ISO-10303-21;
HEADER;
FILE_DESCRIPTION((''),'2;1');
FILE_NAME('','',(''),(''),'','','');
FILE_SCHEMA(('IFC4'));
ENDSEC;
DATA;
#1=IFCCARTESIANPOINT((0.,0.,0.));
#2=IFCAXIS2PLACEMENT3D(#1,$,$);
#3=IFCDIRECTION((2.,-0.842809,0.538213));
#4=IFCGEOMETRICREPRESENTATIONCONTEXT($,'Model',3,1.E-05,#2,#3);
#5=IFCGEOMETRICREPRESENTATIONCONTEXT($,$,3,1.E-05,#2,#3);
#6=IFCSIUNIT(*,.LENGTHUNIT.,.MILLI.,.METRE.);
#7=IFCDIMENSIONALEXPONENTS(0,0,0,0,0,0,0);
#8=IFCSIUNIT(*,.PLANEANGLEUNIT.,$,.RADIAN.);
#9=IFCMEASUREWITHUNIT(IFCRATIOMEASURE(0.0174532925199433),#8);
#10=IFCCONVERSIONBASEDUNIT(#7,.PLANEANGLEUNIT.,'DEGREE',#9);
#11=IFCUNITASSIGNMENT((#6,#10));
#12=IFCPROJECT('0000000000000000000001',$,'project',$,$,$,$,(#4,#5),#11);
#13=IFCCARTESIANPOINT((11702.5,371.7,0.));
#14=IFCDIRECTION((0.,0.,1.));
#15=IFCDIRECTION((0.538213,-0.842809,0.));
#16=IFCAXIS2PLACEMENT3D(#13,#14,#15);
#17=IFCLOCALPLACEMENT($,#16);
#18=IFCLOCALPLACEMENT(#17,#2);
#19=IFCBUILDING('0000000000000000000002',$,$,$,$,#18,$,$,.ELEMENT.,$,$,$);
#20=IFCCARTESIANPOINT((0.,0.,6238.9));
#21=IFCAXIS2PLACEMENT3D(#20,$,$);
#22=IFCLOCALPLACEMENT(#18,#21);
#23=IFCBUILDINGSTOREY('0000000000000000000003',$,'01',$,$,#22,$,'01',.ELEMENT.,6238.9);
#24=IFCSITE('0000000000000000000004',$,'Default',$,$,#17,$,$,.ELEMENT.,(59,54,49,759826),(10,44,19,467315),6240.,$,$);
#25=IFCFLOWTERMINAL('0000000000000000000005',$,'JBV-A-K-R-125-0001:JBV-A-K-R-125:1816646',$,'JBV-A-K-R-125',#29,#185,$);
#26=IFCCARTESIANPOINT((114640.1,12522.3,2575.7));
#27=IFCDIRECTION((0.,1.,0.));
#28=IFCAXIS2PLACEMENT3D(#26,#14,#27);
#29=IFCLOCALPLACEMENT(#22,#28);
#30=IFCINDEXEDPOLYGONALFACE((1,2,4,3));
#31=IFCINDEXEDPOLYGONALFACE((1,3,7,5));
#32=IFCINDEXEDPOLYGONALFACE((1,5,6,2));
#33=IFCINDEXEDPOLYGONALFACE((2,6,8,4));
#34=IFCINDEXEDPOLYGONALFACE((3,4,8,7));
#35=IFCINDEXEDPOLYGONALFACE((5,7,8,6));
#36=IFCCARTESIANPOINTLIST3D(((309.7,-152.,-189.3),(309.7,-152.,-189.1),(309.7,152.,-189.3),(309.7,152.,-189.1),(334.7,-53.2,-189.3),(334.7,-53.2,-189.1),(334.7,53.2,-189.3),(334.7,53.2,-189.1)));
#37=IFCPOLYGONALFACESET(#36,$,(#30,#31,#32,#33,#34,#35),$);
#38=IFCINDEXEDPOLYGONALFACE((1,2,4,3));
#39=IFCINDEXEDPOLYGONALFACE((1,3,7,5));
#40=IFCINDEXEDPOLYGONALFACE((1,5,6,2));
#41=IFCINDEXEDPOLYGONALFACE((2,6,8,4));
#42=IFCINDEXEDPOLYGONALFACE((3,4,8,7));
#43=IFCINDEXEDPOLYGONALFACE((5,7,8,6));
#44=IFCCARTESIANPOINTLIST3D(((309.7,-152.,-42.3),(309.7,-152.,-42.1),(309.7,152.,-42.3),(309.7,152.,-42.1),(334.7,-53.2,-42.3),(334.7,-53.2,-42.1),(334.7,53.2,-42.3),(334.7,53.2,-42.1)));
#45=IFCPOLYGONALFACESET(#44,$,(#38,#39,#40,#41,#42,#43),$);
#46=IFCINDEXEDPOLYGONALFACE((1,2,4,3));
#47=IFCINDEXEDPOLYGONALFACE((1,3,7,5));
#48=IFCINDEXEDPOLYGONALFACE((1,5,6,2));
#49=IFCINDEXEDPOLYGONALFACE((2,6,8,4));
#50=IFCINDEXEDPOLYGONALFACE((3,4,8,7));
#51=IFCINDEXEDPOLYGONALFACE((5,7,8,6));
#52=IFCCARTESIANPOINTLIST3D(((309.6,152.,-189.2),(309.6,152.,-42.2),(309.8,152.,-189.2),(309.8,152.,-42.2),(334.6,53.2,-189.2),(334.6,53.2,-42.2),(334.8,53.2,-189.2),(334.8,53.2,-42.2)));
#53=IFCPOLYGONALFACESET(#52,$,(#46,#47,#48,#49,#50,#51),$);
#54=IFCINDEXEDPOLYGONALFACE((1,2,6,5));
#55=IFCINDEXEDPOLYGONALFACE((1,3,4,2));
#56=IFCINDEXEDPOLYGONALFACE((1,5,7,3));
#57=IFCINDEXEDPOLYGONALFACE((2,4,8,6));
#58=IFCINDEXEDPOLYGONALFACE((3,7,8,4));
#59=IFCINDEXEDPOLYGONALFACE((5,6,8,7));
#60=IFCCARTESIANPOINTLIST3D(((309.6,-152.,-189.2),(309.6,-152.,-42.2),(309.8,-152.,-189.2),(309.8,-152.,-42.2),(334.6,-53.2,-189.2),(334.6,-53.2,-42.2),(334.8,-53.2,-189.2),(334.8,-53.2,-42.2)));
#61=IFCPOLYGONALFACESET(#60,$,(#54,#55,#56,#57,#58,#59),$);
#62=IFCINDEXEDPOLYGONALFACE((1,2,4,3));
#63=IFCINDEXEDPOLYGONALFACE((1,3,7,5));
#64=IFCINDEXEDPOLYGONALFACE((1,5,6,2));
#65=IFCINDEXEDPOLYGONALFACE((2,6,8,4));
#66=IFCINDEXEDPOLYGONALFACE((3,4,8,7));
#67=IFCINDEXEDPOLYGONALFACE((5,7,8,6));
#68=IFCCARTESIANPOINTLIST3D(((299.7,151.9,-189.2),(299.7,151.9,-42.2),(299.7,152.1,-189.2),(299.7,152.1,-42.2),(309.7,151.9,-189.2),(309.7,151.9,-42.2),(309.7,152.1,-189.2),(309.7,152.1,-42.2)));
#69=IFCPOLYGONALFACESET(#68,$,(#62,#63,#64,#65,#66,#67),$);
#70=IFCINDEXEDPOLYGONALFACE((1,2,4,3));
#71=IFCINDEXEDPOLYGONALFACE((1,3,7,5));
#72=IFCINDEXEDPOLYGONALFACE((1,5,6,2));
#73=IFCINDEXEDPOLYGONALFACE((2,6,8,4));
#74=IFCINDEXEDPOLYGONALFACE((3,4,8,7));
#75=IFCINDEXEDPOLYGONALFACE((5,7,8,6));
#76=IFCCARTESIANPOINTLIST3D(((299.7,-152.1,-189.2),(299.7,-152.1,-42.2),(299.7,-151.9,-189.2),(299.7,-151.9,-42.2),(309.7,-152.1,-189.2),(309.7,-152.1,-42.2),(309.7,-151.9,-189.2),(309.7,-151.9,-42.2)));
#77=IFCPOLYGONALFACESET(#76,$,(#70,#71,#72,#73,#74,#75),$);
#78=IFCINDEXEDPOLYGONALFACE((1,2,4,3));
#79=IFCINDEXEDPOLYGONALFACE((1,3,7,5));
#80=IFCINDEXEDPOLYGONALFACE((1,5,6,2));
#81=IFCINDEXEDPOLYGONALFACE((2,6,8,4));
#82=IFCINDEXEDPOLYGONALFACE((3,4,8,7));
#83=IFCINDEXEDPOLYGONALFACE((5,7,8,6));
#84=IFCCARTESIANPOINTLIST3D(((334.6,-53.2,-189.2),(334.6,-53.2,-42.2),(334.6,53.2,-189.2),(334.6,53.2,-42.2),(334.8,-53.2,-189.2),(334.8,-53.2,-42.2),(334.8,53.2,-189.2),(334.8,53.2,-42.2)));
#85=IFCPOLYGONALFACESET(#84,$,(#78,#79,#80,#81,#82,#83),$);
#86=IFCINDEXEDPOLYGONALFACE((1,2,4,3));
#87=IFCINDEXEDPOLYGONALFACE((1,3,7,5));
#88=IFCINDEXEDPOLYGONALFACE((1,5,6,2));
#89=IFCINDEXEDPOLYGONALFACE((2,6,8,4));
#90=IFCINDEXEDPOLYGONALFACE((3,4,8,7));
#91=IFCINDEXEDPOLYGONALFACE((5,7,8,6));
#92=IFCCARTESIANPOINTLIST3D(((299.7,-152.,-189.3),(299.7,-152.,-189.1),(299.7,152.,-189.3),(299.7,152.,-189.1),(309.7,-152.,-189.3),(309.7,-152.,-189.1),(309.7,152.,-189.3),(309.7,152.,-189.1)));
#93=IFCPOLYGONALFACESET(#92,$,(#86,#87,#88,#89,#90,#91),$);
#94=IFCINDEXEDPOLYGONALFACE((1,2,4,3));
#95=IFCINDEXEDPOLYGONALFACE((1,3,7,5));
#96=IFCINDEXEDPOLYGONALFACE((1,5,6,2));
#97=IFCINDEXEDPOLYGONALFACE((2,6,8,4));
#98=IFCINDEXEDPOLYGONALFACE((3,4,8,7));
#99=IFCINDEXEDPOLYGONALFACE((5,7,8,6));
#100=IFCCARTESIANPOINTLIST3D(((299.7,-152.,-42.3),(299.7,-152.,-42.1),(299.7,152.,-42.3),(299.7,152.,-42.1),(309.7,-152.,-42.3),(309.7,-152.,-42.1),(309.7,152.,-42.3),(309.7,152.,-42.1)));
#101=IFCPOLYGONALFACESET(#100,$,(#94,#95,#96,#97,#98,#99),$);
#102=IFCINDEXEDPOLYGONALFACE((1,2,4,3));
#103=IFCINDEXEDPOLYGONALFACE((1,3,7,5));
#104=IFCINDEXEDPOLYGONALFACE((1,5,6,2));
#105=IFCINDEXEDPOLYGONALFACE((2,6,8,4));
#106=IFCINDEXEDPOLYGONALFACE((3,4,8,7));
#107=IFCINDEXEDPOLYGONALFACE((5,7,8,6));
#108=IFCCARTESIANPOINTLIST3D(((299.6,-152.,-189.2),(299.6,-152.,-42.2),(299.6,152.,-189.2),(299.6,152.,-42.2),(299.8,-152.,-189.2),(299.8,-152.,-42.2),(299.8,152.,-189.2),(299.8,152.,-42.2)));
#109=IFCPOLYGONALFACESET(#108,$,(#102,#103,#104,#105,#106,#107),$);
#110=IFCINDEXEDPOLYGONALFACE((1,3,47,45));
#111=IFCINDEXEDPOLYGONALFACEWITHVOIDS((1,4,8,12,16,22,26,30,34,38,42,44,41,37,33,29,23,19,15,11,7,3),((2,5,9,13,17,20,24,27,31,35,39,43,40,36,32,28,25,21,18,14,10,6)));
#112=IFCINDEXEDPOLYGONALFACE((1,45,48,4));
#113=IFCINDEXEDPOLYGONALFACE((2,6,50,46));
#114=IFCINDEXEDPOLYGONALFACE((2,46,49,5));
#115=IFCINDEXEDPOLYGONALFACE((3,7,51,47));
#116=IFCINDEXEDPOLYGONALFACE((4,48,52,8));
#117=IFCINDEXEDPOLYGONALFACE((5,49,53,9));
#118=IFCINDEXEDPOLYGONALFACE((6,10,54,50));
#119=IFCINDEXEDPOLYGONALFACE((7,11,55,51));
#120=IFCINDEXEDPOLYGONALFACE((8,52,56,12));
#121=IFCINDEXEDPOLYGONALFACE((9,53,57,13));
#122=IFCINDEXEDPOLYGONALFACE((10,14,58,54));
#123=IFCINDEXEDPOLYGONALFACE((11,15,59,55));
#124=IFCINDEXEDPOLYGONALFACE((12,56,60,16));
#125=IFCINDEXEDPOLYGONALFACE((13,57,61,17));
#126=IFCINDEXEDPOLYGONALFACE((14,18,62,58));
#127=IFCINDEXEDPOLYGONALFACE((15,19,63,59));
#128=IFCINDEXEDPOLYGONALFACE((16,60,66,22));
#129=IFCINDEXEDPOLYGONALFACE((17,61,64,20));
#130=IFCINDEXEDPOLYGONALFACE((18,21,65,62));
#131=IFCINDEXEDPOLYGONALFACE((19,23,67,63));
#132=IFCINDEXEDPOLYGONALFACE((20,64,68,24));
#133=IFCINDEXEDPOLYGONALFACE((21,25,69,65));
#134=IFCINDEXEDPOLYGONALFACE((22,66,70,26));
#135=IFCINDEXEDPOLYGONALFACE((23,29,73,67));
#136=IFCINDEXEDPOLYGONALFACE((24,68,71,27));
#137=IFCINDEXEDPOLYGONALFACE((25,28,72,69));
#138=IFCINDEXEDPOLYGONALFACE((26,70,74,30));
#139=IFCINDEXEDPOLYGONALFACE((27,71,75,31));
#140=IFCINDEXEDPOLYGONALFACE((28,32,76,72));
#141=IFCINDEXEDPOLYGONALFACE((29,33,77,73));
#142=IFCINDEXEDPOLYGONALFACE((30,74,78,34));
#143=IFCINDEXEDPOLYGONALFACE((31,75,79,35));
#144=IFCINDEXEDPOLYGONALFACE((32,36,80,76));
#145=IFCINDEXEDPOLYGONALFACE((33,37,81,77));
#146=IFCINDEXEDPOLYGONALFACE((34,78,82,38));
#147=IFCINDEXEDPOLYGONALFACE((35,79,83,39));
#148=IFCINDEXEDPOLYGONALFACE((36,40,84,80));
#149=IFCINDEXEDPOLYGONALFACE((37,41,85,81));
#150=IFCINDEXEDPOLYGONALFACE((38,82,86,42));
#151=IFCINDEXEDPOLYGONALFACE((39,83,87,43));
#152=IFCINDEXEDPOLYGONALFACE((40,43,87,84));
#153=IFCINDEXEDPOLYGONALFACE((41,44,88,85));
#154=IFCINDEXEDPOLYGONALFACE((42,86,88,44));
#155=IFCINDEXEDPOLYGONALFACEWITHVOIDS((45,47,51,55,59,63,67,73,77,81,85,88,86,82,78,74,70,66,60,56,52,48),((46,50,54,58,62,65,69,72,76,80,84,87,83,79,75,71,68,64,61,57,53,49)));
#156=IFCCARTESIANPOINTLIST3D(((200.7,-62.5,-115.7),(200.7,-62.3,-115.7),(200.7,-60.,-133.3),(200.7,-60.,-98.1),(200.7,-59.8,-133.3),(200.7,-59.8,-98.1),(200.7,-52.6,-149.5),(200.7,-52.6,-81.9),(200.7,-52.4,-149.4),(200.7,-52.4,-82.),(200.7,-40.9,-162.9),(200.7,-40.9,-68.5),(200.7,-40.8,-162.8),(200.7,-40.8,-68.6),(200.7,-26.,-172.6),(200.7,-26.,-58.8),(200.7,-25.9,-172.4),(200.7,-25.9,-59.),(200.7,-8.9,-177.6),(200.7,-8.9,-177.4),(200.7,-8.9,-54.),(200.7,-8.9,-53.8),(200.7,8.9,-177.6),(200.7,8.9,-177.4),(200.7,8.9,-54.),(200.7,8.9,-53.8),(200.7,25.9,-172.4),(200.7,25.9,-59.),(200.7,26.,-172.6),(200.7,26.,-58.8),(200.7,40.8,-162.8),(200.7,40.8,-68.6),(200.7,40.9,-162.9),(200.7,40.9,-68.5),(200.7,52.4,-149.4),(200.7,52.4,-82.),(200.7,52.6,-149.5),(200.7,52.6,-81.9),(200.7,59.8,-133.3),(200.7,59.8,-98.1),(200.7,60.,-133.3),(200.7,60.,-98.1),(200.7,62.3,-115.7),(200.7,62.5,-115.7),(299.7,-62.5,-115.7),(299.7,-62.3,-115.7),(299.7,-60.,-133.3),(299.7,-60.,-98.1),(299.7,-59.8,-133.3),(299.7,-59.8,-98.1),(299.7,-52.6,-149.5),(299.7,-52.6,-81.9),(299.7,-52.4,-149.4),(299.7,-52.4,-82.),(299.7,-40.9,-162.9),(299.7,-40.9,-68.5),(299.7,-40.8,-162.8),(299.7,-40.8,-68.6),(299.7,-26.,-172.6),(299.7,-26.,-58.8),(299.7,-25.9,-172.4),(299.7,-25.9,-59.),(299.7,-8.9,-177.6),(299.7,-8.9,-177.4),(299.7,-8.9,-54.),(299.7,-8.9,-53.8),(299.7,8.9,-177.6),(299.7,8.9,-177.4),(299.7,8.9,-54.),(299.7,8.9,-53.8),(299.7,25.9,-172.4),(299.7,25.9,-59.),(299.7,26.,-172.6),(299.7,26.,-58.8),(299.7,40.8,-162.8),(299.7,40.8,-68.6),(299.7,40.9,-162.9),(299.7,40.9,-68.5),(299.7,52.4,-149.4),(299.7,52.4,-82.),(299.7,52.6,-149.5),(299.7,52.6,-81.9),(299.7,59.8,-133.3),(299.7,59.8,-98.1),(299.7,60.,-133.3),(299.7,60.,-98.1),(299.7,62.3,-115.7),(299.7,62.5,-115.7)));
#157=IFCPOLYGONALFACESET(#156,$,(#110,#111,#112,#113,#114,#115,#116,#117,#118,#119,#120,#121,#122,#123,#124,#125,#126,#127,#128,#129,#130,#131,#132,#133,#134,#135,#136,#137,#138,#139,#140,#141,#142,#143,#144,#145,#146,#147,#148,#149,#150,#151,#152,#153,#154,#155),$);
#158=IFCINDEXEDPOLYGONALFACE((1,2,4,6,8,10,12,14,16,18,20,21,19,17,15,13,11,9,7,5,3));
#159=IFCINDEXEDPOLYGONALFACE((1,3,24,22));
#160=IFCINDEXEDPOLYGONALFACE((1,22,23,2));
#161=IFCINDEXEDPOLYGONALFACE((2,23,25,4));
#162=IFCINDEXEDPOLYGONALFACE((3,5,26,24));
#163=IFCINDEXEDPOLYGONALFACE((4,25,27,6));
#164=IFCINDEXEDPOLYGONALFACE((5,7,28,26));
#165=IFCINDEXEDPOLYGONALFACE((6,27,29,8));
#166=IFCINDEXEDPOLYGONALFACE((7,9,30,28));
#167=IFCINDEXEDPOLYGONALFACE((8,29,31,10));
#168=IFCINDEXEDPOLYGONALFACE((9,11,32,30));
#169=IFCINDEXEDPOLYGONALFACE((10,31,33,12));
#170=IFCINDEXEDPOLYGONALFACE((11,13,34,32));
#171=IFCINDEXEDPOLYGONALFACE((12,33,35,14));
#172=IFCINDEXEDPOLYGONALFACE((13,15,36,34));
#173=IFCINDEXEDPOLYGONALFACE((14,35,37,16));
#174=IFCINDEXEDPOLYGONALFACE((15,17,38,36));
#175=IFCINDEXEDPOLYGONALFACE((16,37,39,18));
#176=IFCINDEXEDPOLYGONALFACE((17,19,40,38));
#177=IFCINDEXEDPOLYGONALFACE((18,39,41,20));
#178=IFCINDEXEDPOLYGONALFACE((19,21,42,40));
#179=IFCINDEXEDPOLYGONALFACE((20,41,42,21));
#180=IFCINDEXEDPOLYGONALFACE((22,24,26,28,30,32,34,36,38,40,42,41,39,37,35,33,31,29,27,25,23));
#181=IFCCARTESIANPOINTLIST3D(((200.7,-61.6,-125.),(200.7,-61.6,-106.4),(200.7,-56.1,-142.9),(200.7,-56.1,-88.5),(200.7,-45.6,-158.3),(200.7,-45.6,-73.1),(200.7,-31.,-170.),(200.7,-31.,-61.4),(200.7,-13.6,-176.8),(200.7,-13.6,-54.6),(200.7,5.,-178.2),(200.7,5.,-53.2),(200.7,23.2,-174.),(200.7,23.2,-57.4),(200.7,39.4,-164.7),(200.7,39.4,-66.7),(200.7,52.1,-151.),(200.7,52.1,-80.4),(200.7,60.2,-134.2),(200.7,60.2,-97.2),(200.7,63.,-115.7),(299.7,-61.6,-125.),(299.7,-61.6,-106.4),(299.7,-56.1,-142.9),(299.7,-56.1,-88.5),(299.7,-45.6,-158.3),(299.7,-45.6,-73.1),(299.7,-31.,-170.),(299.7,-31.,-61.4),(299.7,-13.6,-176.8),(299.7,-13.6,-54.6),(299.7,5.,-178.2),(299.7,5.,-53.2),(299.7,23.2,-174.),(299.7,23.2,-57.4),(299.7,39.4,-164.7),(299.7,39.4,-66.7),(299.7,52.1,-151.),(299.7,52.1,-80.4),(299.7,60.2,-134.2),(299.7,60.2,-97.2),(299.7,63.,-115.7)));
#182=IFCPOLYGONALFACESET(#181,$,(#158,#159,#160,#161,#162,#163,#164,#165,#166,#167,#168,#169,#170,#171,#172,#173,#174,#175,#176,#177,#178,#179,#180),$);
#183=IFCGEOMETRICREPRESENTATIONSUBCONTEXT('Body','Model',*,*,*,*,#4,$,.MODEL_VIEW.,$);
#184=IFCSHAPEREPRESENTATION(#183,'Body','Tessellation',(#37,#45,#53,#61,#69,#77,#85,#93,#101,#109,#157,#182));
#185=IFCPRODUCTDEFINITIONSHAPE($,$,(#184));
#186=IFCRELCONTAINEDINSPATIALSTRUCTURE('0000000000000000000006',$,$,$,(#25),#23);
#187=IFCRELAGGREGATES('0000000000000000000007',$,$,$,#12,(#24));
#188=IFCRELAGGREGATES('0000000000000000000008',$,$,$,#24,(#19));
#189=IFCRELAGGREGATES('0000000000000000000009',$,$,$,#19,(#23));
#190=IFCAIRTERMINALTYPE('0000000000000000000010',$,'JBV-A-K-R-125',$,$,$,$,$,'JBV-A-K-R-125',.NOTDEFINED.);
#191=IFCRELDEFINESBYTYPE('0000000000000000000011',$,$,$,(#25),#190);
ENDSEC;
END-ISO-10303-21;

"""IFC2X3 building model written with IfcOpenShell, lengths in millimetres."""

from ifc_helpers import new_model, entity, si_unit, converted_unit, direction, frame, frame_2d, origin, origin_2d_with_axis, place, context, subcontext, project, spatial, polyline, circle_curve, parameter, trimmed, segment, composite_curve, rectangle, circle, outline, extrude, source, transform, mapped, type_object, type_shapes, element, save


model = new_model("IFC2X3")

# Units and contexts
model_context = context("Model", 3, precision=1e-05, world=origin(), true_north=direction((2.0, -0.842809, 0.538213)))
context_of_model = context(None, 3, precision=1e-05, world=origin(), true_north=direction((2.0, -0.842809, 0.538213)))
body_context = subcontext(model_context, "Body", "Model", "MODEL_VIEW")
ifc_project = project(units=[si_unit("LENGTHUNIT", "METRE", prefix="MILLI"), converted_unit("PLANEANGLEUNIT", "DEGREE", entity("IfcRatioMeasure", 0.0174532925199433), si_unit("PLANEANGLEUNIT", "RADIAN"), dimensions=[0, 0, 0, 0, 0, 0, 0])], contexts=[model_context, context_of_model])

# Site, building, storey
site_placement = place(None, frame((11702.5, 371.7, 0.0), z_axis=(0.0, 0.0, 1.0), x_axis=(0.538213, -0.842809, 0.0)))
site = spatial("IfcSite", under=ifc_project, at=site_placement, Name="Default", CompositionType="ELEMENT", RefLatitude=(59, 54, 49, 759826), RefLongitude=(10, 44, 19, 467315), RefElevation=6240.0)
building_placement = place(site_placement, origin())
building = spatial("IfcBuilding", under=site, at=building_placement, CompositionType="ELEMENT")
storey_placement = place(building_placement, frame((0.0, 0.0, 6238.9)))
storey = spatial("IfcBuildingStorey", under=building, at=storey_placement, Name="01", LongName="01", CompositionType="ELEMENT", Elevation=6238.9)

# Flow terminal
air_terminal_type_1 = type_object("IfcAirTerminalType", Name="JBV-A-K-R-125", ElementType="JBV-A-K-R-125", PredefinedType="NOTDEFINED")
shared_shape_1 = source(origin(), body_context, "Body", "SweptSolid", [
    extrude(outline(polyline([(-152.0, -12.5), (152.0, -12.5), (53.2, 12.5), (-53.2, 12.5), (-152.0, -12.5)])), frame((322.2, 0.0, -189.3), z_axis=(0.0, 0.0, 1.0), x_axis=(0.0, -1.0, 0.0)), (0.0, 0.0, 1.0), 0.2),
    extrude(outline(polyline([(-152.0, -12.5), (152.0, -12.5), (53.2, 12.5), (-53.2, 12.5), (-152.0, -12.5)])), frame((322.2, 0.0, -42.3), z_axis=(0.0, 0.0, 1.0), x_axis=(0.0, -1.0, 0.0)), (0.0, 0.0, 1.0), 0.2),
    extrude(rectangle(XDim=0.2, YDim=101.9, at=frame_2d((0.0, 0.0), x_axis=(1.0, 0.0))), frame((322.2, 102.6, -189.2), z_axis=(0.0, 0.0, 1.0), x_axis=(0.969446, 0.245305, 0.0)), (0.0, 0.0, 1.0), 147.0),
    extrude(rectangle(XDim=0.2, YDim=101.9, at=frame_2d((0.0, 0.0), x_axis=(1.0, 0.0))), frame((322.2, -102.6, -189.2), z_axis=(0.0, 0.0, 1.0), x_axis=(-0.969446, 0.245305, 0.0)), (0.0, 0.0, 1.0), 147.0),
    extrude(rectangle(XDim=0.2, YDim=10.0, at=frame_2d((0.0, 0.0), x_axis=(1.0, 0.0))), frame((304.7, 152.0, -189.2), z_axis=(0.0, 0.0, 1.0), x_axis=(0.0, 1.0, 0.0)), (0.0, 0.0, 1.0), 147.0),
    extrude(rectangle(XDim=0.2, YDim=10.0, at=frame_2d((0.0, 0.0), x_axis=(1.0, 0.0))), frame((304.7, -152.0, -189.2), z_axis=(0.0, 0.0, 1.0), x_axis=(0.0, 1.0, 0.0)), (0.0, 0.0, 1.0), 147.0),
    extrude(rectangle(XDim=0.2, YDim=106.4, at=frame_2d((0.0, 0.0), x_axis=(1.0, 0.0))), frame((334.7, 0.0, -189.2)), (0.0, 0.0, 1.0), 147.0),
    extrude(rectangle(XDim=304.0, YDim=10.0, at=frame_2d((0.0, 0.0), x_axis=(1.0, 0.0))), frame((304.7, 0.0, -189.3), z_axis=(0.0, 0.0, 1.0), x_axis=(0.0, -1.0, 0.0)), (0.0, 0.0, 1.0), 0.2),
    extrude(rectangle(XDim=304.0, YDim=10.0, at=frame_2d((0.0, 0.0), x_axis=(1.0, 0.0))), frame((304.7, 0.0, -42.3), z_axis=(0.0, 0.0, 1.0), x_axis=(0.0, -1.0, 0.0)), (0.0, 0.0, 1.0), 0.2),
    extrude(rectangle(XDim=0.2, YDim=304.0, at=frame_2d((0.0, 0.0), x_axis=(1.0, 0.0))), frame((299.7, 0.0, -189.2)), (0.0, 0.0, 1.0), 147.0),
    extrude(outline(composite_curve([segment(trimmed(circle_curve(origin_2d_with_axis(), 62.5), [parameter(0.0)], [parameter(180.0)], True, "PARAMETER"), True, "CONTINUOUS"), segment(trimmed(circle_curve(origin_2d_with_axis(), 62.5), [parameter(180.0)], [parameter(360.0)], True, "PARAMETER"), True, "CONTINUOUS")], self_intersect=False), holes=[composite_curve([segment(trimmed(circle_curve(origin_2d_with_axis(), 62.3), [parameter(180.0)], [parameter(360.0)], True, "PARAMETER"), False, "CONTINUOUS"), segment(trimmed(circle_curve(origin_2d_with_axis(), 62.3), [parameter(0.0)], [parameter(180.0)], True, "PARAMETER"), False, "CONTINUOUS")], self_intersect=False)]), frame((200.7, 0.0, -115.7), z_axis=(1.0, 0.0, 0.0), x_axis=(0.0, 1.0, 0.0)), (0.0, 0.0, 1.0), 99.0),
    extrude(circle(Radius=62.6, at=frame_2d((0.0, 0.0), x_axis=(1.0, 0.0))), frame((200.7, 0.3, -115.7), z_axis=(1.0, 0.0, 0.0), x_axis=(0.0, 1.0, 0.0)), (0.0, 0.0, 1.0), 99.0),
])
type_shapes(air_terminal_type_1, [shared_shape_1])
for number, where, z_axis, x_axis, name in (
    (1, (114640.1, 12522.3, 2575.7), (0.0, 0.0, 1.0), (0.0, 1.0, 0.0), "JBV-A-K-R-125-0001:JBV-A-K-R-125:1816646"),
):
    element("IfcFlowTerminal", number, at=place(storey_placement, frame(where, z_axis=z_axis, x_axis=x_axis)), inside=storey, type_object=air_terminal_type_1, Name=name, ObjectType="JBV-A-K-R-125", context=body_context, shape_type="MappedRepresentation", body=[
        mapped(shared_shape_1, transform((0.0, 0.0, 0.0), scale=1.0)),
    ])

save(model, "model.ifc")
